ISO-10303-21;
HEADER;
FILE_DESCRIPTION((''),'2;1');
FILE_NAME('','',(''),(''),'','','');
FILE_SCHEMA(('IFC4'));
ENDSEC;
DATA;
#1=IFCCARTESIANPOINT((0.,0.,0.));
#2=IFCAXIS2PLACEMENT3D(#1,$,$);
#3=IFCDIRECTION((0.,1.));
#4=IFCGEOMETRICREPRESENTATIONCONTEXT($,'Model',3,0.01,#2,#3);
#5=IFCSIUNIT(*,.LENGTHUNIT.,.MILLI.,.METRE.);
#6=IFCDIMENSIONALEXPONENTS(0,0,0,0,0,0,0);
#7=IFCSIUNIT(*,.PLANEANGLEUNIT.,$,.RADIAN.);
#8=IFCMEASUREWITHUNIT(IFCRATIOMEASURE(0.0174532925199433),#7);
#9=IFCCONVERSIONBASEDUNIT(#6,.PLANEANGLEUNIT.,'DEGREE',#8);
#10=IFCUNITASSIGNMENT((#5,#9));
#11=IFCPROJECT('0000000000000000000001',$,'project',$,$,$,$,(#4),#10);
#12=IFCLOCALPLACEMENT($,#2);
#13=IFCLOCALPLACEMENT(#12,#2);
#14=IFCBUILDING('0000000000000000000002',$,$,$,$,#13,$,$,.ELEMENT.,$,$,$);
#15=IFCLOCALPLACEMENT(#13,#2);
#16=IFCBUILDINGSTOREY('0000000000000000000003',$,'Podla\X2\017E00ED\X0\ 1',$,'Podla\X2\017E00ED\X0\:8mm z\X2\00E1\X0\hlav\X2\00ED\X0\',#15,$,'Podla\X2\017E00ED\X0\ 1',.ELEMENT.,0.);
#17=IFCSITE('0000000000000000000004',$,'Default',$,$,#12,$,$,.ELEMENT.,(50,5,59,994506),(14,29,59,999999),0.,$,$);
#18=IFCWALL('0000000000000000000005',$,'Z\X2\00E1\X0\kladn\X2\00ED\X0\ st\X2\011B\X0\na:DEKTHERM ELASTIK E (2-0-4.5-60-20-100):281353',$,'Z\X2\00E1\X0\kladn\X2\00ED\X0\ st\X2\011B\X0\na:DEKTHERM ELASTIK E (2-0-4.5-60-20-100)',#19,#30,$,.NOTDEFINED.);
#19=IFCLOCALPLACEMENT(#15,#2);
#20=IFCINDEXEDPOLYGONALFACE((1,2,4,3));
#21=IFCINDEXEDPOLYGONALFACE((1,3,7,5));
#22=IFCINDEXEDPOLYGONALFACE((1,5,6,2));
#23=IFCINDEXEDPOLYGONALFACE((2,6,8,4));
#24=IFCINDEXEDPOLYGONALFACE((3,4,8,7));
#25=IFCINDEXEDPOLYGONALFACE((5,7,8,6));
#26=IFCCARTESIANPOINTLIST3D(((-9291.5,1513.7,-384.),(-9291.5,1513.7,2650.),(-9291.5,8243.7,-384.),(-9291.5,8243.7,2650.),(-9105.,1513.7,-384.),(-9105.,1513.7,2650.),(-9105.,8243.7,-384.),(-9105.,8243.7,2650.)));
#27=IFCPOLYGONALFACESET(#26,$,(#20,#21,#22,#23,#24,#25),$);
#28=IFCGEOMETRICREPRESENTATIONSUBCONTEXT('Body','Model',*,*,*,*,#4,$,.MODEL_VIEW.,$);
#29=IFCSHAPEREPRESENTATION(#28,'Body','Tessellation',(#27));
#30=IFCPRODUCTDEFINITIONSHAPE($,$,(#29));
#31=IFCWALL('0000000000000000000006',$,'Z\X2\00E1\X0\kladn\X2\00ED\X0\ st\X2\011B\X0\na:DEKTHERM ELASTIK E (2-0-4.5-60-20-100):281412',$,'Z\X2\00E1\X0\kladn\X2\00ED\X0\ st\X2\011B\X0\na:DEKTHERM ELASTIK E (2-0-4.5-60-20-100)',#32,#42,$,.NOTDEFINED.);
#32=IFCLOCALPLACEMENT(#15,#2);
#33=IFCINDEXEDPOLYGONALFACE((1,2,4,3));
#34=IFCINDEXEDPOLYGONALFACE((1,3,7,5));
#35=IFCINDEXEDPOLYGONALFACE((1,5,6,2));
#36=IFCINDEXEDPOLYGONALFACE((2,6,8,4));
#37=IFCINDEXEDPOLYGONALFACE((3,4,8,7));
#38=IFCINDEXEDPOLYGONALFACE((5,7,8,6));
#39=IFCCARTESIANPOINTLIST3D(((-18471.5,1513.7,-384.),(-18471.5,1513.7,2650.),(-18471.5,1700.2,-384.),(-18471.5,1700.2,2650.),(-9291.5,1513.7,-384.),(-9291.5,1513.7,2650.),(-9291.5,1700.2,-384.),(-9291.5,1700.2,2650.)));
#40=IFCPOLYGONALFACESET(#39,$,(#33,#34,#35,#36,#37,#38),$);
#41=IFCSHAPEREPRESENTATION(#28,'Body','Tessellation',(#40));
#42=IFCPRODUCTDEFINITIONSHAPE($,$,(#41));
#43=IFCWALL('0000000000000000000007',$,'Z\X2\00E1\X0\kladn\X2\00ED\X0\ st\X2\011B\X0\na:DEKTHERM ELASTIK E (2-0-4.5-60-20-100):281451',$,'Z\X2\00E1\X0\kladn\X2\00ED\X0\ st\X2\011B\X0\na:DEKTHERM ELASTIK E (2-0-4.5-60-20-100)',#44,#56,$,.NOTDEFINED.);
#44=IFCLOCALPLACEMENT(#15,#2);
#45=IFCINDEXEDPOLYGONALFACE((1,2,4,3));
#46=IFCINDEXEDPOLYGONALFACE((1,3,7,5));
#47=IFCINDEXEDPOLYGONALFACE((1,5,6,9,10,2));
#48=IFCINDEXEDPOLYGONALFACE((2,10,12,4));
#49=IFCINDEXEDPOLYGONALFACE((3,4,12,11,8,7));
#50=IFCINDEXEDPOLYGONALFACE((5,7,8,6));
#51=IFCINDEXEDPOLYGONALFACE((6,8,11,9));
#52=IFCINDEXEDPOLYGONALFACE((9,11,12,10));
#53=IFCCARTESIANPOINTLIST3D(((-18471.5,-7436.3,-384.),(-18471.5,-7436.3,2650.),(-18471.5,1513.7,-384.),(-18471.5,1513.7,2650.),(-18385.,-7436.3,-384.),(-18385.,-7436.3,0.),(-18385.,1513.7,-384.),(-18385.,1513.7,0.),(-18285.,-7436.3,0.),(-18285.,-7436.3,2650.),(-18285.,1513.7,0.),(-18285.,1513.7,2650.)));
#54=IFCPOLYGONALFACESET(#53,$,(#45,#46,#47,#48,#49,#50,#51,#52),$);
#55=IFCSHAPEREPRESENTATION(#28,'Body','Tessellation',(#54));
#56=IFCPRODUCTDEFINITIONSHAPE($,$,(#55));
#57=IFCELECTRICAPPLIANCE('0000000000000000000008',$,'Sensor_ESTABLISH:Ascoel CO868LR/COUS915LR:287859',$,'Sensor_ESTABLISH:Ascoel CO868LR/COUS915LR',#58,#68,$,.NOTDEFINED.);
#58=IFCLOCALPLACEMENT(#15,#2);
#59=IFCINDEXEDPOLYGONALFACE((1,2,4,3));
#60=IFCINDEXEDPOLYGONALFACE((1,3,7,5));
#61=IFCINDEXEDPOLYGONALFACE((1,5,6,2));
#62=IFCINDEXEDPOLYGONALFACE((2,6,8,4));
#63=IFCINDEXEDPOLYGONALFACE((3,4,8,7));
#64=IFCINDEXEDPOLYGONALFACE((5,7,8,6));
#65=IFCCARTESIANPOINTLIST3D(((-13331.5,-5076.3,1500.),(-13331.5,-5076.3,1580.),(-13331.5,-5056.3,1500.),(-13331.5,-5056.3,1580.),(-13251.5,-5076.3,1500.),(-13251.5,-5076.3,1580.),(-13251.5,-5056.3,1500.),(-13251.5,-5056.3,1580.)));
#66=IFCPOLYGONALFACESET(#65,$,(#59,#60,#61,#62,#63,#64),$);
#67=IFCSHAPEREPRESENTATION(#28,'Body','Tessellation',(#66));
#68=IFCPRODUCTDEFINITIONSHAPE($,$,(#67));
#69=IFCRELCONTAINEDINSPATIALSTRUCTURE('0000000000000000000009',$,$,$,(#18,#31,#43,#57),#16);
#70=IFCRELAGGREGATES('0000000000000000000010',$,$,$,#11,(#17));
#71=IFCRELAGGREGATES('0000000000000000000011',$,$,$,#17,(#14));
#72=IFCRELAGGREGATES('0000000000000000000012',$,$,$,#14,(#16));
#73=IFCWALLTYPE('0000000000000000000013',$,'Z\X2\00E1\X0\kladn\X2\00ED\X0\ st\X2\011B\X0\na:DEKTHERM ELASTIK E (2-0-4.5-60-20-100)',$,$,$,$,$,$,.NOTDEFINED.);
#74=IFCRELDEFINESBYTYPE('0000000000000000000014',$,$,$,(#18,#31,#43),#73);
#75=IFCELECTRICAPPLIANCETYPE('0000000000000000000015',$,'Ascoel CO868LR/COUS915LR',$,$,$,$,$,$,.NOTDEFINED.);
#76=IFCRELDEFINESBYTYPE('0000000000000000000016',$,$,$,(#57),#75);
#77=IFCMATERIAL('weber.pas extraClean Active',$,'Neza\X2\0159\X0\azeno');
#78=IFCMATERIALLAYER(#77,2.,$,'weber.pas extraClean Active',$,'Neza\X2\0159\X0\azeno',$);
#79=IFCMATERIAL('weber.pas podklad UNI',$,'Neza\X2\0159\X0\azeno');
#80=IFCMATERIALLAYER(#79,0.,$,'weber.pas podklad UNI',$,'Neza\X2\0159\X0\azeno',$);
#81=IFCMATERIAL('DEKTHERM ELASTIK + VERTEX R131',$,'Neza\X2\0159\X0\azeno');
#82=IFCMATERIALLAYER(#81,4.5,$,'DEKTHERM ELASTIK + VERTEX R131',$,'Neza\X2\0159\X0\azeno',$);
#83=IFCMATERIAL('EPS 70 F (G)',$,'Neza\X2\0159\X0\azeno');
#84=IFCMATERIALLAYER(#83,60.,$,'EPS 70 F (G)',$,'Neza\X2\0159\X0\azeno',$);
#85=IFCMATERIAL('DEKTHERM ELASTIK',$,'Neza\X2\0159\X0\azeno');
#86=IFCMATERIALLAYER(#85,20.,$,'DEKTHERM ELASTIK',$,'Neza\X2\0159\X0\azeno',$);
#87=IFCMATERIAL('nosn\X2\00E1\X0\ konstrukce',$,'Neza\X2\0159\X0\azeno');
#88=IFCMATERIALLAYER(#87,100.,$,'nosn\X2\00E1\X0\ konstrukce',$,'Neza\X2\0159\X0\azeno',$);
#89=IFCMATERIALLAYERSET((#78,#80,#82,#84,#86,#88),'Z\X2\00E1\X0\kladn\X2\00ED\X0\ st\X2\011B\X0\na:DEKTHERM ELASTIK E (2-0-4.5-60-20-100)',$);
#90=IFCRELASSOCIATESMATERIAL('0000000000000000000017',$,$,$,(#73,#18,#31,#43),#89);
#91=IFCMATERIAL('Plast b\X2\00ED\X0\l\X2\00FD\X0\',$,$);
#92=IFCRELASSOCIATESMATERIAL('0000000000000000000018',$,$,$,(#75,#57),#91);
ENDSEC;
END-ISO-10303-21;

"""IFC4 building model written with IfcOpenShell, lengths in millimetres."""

from ifc_helpers import new_model, entity, si_unit, converted_unit, direction, frame, frame_2d, origin, origin_2d_with_axis, place, context, subcontext, project, spatial, polyline, rectangle, extrude, clip, halfspace, bounded_halfspace, source, transform, mapped, material, layer, layer_set, layer_usage, type_object, type_shapes, element, save


model = new_model("IFC4")

# Units and contexts
model_context = context("Model", 3, precision=0.01, world=origin(), true_north=direction((0.0, 1.0)))
body_context = subcontext(model_context, "Body", "Model", "MODEL_VIEW")
ifc_project = project(units=[si_unit("LENGTHUNIT", "METRE", prefix="MILLI"), converted_unit("PLANEANGLEUNIT", "DEGREE", entity("IfcRatioMeasure", 0.0174532925199433), si_unit("PLANEANGLEUNIT", "RADIAN"), dimensions=[0, 0, 0, 0, 0, 0, 0])], contexts=[model_context])

# Site, building, storey
site_placement = place(None, origin())
site = spatial("IfcSite", under=ifc_project, at=site_placement, Name="Default", CompositionType="ELEMENT", RefLatitude=(50, 5, 59, 994506), RefLongitude=(14, 29, 59, 999999), RefElevation=0.0)
building_placement = place(site_placement, origin())
building = spatial("IfcBuilding", under=site, at=building_placement, CompositionType="ELEMENT")
storey_placement = place(building_placement, origin())
storey = spatial("IfcBuildingStorey", under=building, at=storey_placement, Name="Podlaží 1", ObjectType="Podlaží:8mm záhlaví", LongName="Podlaží 1", CompositionType="ELEMENT", Elevation=0.0)

# Walls
ifc_material_1 = material(Name="weber.pas extraClean Active", Category="Nezařazeno")
ifc_layer_1 = layer(ifc_material_1, 2.0, Name="weber.pas extraClean Active", Category="Nezařazeno")
ifc_material_2 = material(Name="weber.pas podklad UNI", Category="Nezařazeno")
ifc_layer_2 = layer(ifc_material_2, 0.0, Name="weber.pas podklad UNI", Category="Nezařazeno")
ifc_material_3 = material(Name="DEKTHERM ELASTIK + VERTEX R131", Category="Nezařazeno")
ifc_layer_3 = layer(ifc_material_3, 4.5, Name="DEKTHERM ELASTIK + VERTEX R131", Category="Nezařazeno")
ifc_material_4 = material(Name="EPS 70 F (G)", Category="Nezařazeno")
ifc_layer_4 = layer(ifc_material_4, 60.0, Name="EPS 70 F (G)", Category="Nezařazeno")
ifc_material_5 = material(Name="DEKTHERM ELASTIK", Category="Nezařazeno")
ifc_layer_5 = layer(ifc_material_5, 20.0, Name="DEKTHERM ELASTIK", Category="Nezařazeno")
ifc_material_6 = material(Name="nosná konstrukce", Category="Nezařazeno")
ifc_layer_6 = layer(ifc_material_6, 100.0, Name="nosná konstrukce", Category="Nezařazeno")
ifc_layer_set_1 = layer_set([ifc_layer_1, ifc_layer_2, ifc_layer_3, ifc_layer_4, ifc_layer_5, ifc_layer_6], Name="Základní stěna:DEKTHERM ELASTIK E (2-0-4.5-60-20-100)")
ifc_layer_usage_1 = layer_usage(ifc_layer_set_1, "AXIS2", "POSITIVE", -93.2)
wall_type_1 = type_object("IfcWallType", Name="Základní stěna:DEKTHERM ELASTIK E (2-0-4.5-60-20-100)", PredefinedType="NOTDEFINED", material=ifc_layer_set_1)
wall_1_placement = place(storey_placement, frame((-9198.2, 8243.7, -384.0), z_axis=(0.0, 0.0, 1.0), x_axis=(0.0, -1.0, 0.0)))
element("IfcWall", 1, at=wall_1_placement, inside=storey, type_object=wall_type_1, material=ifc_layer_usage_1, Name="Základní stěna:DEKTHERM ELASTIK E (2-0-4.5-60-20-100):281353", ObjectType="Základní stěna:DEKTHERM ELASTIK E (2-0-4.5-60-20-100)", PredefinedType="NOTDEFINED", context=body_context, shape_type="Clipping", body=[
    clip(extrude(rectangle(XDim=6730.0, YDim=186.5, at=frame_2d((3365.0, 0.0), x_axis=(-1.0, 0.0))), origin(), (0.0, 0.0, 1.0), 3034.0), halfspace(frame((0.0, 0.0, -384.0)), True)),
])
ifc_layer_usage_2 = layer_usage(ifc_layer_set_1, "AXIS2", "POSITIVE", -93.2)
wall_2_placement = place(storey_placement, frame((-9291.5, 1607.0, -384.0), z_axis=(0.0, 0.0, 1.0), x_axis=(-1.0, 0.0, 0.0)))
element("IfcWall", 2, at=wall_2_placement, inside=storey, type_object=wall_type_1, material=ifc_layer_usage_2, Name="Základní stěna:DEKTHERM ELASTIK E (2-0-4.5-60-20-100):281412", ObjectType="Základní stěna:DEKTHERM ELASTIK E (2-0-4.5-60-20-100)", PredefinedType="NOTDEFINED", context=body_context, shape_type="Clipping", body=[
    clip(extrude(rectangle(XDim=9180.0, YDim=186.5, at=frame_2d((4590.0, 0.0), x_axis=(-1.0, 0.0))), origin(), (0.0, 0.0, 1.0), 3034.0), halfspace(frame((0.0, 0.0, -384.0)), True)),
])
ifc_layer_usage_3 = layer_usage(ifc_layer_set_1, "AXIS2", "POSITIVE", -93.2)
wall_3_placement = place(storey_placement, frame((-18378.2, 1513.7, -384.0), z_axis=(0.0, 0.0, 1.0), x_axis=(0.0, -1.0, 0.0)))
element("IfcWall", 3, at=wall_3_placement, inside=storey, type_object=wall_type_1, material=ifc_layer_usage_3, Name="Základní stěna:DEKTHERM ELASTIK E (2-0-4.5-60-20-100):281451", ObjectType="Základní stěna:DEKTHERM ELASTIK E (2-0-4.5-60-20-100)", PredefinedType="NOTDEFINED", context=body_context, shape_type="Clipping", body=[
    clip(clip(clip(extrude(rectangle(XDim=8950.0, YDim=186.5, at=frame_2d((4475.0, 0.0), x_axis=(-1.0, 0.0))), origin(), (0.0, 0.0, 1.0), 3034.0), bounded_halfspace(frame((8950.0, -6.8, 384.0), z_axis=(0.0, 0.0, 1.0), x_axis=(0.0, -1.0, 0.0)), True, frame((8950.0, -6.8, 384.0), z_axis=(0.0, 0.0, 1.0), x_axis=(0.0, -1.0, 0.0)), polyline([(0.0, 0.0), (-100.0, 0.0), (-100.0, -8950.0), (0.0, -8950.0), (0.0, 0.0)]))), bounded_halfspace(frame((0.0, -6.8, 384.0), z_axis=(0.0, -1.0, 0.0), x_axis=(0.0, 0.0, 1.0)), True, frame((0.0, -6.8, 384.0), z_axis=(0.0, -1.0, 0.0), x_axis=(0.0, 0.0, 1.0)), polyline([(0.0, 0.0), (-384.0, 0.0), (-384.0, -8950.0), (0.0, -8950.0), (0.0, 0.0)]))), halfspace(frame((0.0, 0.0, -384.0)), True)),
])

# Electric appliance
ifc_material_7 = material(Name="Plast bílý")
electric_appliance_type_1 = type_object("IfcElectricApplianceType", Name="Ascoel CO868LR/COUS915LR", PredefinedType="NOTDEFINED", material=ifc_material_7)
shared_shape_1 = source(origin(), body_context, "Body", "SweptSolid", [
    extrude(rectangle(XDim=80.0, YDim=20.0, at=origin_2d_with_axis()), frame((0.0, 0.0, 0.0), z_axis=(0.0, 0.0, 1.0), x_axis=(-1.0, 0.0, 0.0)), (0.0, 0.0, 1.0), 80.0),
])
type_shapes(electric_appliance_type_1, [shared_shape_1])
electric_appliance_1_placement = place(storey_placement, frame((-13291.5, -5066.3, 1500.0)))
element("IfcElectricAppliance", 4, at=electric_appliance_1_placement, inside=storey, type_object=electric_appliance_type_1, material=ifc_material_7, Name="Sensor_ESTABLISH:Ascoel CO868LR/COUS915LR:287859", ObjectType="Sensor_ESTABLISH:Ascoel CO868LR/COUS915LR", PredefinedType="NOTDEFINED", context=body_context, shape_type="MappedRepresentation", body=[
    mapped(shared_shape_1, transform((0.0, 0.0, 0.0), scale=1.0)),
])

save(model, "model.ifc")
